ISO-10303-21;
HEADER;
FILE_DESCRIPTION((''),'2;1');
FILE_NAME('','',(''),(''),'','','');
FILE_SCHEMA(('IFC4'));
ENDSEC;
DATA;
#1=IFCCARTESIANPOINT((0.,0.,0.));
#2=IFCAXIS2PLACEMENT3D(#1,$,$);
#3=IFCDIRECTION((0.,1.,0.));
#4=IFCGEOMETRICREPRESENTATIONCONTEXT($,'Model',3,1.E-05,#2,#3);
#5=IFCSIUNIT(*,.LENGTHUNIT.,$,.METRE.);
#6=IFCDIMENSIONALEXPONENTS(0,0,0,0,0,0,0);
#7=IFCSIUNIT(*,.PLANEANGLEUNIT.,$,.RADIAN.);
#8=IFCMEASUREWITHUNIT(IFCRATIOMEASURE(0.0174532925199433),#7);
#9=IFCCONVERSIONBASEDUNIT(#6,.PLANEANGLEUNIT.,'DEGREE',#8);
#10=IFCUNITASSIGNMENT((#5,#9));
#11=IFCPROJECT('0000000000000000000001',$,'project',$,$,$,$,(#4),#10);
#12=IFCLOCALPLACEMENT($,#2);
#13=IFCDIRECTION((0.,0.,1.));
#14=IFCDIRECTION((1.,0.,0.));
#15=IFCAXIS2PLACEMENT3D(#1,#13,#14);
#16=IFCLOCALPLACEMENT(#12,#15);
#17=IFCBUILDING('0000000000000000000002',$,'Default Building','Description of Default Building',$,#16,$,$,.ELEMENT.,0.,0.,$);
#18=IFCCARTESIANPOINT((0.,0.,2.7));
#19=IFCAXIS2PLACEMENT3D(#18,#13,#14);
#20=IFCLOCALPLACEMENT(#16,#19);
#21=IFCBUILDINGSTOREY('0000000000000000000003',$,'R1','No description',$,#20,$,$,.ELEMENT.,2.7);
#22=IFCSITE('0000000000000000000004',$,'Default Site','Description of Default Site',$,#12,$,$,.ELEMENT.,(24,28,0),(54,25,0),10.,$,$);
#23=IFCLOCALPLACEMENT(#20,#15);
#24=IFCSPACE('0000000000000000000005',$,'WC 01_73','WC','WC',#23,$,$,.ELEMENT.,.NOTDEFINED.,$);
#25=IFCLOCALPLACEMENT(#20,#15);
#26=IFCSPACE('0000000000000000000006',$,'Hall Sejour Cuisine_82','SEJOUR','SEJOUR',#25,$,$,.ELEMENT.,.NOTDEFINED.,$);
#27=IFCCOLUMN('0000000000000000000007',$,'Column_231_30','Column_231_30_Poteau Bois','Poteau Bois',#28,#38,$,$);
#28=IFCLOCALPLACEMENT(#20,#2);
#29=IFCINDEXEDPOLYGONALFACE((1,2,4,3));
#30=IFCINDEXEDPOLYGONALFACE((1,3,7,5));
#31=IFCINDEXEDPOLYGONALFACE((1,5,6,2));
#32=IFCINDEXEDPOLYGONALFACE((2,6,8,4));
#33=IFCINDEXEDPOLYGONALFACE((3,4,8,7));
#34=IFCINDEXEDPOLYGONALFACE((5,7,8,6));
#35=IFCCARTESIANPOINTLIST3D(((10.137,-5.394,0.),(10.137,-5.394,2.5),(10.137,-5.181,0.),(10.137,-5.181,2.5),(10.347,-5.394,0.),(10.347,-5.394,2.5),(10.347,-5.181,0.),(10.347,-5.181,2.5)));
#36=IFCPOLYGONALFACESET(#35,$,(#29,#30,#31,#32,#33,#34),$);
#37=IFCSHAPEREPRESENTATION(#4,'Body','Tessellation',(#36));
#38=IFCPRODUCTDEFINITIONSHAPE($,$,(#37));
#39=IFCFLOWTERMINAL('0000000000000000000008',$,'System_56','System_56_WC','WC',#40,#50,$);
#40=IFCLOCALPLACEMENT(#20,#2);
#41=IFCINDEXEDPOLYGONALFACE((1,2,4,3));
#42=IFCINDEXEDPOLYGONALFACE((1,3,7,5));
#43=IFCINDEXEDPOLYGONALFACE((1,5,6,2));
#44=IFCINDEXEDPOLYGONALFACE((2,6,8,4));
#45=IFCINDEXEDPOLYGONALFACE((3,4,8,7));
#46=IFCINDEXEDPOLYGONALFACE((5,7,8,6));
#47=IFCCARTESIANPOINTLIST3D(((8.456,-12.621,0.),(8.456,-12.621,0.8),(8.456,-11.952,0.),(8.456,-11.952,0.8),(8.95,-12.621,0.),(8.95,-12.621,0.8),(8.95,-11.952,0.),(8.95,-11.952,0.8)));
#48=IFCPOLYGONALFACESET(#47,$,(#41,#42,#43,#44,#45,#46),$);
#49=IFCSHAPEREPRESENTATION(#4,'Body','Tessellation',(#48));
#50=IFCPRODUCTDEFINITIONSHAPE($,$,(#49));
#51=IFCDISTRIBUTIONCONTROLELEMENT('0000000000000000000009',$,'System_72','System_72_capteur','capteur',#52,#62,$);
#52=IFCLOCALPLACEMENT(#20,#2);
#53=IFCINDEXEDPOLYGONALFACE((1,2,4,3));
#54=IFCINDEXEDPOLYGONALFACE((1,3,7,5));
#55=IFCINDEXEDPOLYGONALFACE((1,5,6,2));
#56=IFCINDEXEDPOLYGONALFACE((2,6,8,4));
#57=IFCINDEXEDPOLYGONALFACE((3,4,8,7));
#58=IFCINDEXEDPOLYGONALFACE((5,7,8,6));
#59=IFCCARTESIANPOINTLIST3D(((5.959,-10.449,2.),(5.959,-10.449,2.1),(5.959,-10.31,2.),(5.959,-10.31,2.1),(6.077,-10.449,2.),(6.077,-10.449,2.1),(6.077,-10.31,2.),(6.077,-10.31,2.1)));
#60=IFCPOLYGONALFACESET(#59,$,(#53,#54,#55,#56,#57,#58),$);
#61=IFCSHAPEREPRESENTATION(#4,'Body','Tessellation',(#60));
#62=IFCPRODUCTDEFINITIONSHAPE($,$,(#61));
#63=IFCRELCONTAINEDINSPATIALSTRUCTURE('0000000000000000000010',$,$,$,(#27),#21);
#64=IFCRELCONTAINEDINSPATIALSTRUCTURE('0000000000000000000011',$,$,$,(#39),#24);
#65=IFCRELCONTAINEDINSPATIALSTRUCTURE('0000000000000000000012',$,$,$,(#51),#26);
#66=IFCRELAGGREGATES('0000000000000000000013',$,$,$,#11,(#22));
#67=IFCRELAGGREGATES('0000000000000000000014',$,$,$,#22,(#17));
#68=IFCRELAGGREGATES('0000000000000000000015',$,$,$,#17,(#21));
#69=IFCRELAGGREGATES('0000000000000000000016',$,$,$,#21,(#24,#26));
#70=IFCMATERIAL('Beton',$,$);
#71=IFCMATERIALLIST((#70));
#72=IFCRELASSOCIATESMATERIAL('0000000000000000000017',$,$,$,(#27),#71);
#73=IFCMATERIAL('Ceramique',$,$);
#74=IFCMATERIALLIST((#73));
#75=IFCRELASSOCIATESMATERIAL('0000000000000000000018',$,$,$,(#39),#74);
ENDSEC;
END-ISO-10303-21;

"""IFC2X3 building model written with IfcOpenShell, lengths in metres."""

from ifc_helpers import new_model, entity, si_unit, converted_unit, direction, frame, origin, origin_with_axes, place, context, project, spatial, polyline, outline, extrude, material, material_list, element, save


model = new_model("IFC2X3")

# Units and contexts
model_context = context("Model", 3, precision=1e-05, world=origin(), true_north=direction((0.0, 1.0, 0.0)))
ifc_project = project(units=[si_unit("LENGTHUNIT", "METRE"), converted_unit("PLANEANGLEUNIT", "DEGREE", entity("IfcRatioMeasure", 0.0174532925199433), si_unit("PLANEANGLEUNIT", "RADIAN"), dimensions=[0, 0, 0, 0, 0, 0, 0])], contexts=[model_context])

# Site, building, storey
site_placement = place(None, origin())
site = spatial("IfcSite", under=ifc_project, at=site_placement, Name="Default Site", Description="Description of Default Site", CompositionType="ELEMENT", RefLatitude=(24, 28, 0), RefLongitude=(54, 25, 0), RefElevation=10.0)
building_placement = place(site_placement, origin_with_axes())
building = spatial("IfcBuilding", under=site, at=building_placement, Name="Default Building", Description="Description of Default Building", CompositionType="ELEMENT", ElevationOfRefHeight=0.0, ElevationOfTerrain=0.0)
storey_placement = place(building_placement, frame((0.0, 0.0, 2.7), z_axis=(0.0, 0.0, 1.0), x_axis=(1.0, 0.0, 0.0)))
storey = spatial("IfcBuildingStorey", under=building, at=storey_placement, Name="R1", Description="No description", CompositionType="ELEMENT", Elevation=2.7)

# Column
ifc_material_1 = material(Name="Beton")
ifc_material_list_1 = material_list([ifc_material_1])
column_placement = place(storey_placement, frame((10.242, -5.181, 0.0), z_axis=(0.0, 0.0, 1.0), x_axis=(0.0, -0.213, 0.0)))
element("IfcColumn", 1, at=column_placement, inside=storey, material=ifc_material_list_1, Name="Column_231_30", Description="Column_231_30_Poteau Bois", ObjectType="Poteau Bois", context=model_context, shape_type="SweptSolid", body=[
    extrude(outline(polyline([(0.0, -0.105), (0.213, -0.105), (0.213, 0.105), (0.0, 0.105), (0.0, -0.105)])), origin(), (0.0, 0.0, 1.0), 2.5),
])

# Shared definitions
space_1_placement = place(storey_placement, origin_with_axes())
space_1 = spatial("IfcSpace", under=storey, at=space_1_placement, Name="WC 01_73", Description="WC", ObjectType="WC", CompositionType="ELEMENT", InteriorOrExteriorSpace="NOTDEFINED")

# Shared definitions
space_2_placement = place(storey_placement, origin_with_axes())
space_2 = spatial("IfcSpace", under=storey, at=space_2_placement, Name="Hall Sejour Cuisine_82", Description="SEJOUR", ObjectType="SEJOUR", CompositionType="ELEMENT", InteriorOrExteriorSpace="NOTDEFINED")

# Flow terminal
ifc_material_2 = material(Name="Ceramique")
ifc_material_list_2 = material_list([ifc_material_2])
flow_terminal_placement = place(storey_placement, frame((8.703, -11.952, 0.0), z_axis=(0.0, 0.0, 1.0), x_axis=(0.0, -0.669, 0.0)))
element("IfcFlowTerminal", 2, at=flow_terminal_placement, inside=space_1, material=ifc_material_list_2, Name="System_56", Description="System_56_WC", ObjectType="WC", context=model_context, shape_type="SweptSolid", body=[
    extrude(outline(polyline([(0.0, -0.247), (0.669, -0.247), (0.669, 0.247), (0.0, 0.247), (0.0, -0.247)])), origin(), (0.0, 0.0, 1.0), 0.8),
])

# Distribution control element
distribution_control_element_placement = place(storey_placement, frame((6.018, -10.31, 2.0), z_axis=(0.0, 0.0, 1.0), x_axis=(0.0, -0.139, 0.0)))
element("IfcDistributionControlElement", 3, at=distribution_control_element_placement, inside=space_2, Name="System_72", Description="System_72_capteur", ObjectType="capteur", context=model_context, shape_type="SweptSolid", body=[
    extrude(outline(polyline([(0.0, -0.059), (0.139, -0.059), (0.139, 0.059), (0.0, 0.059), (0.0, -0.059)])), origin(), (0.0, 0.0, 1.0), 0.1),
])

save(model, "model.ifc")
